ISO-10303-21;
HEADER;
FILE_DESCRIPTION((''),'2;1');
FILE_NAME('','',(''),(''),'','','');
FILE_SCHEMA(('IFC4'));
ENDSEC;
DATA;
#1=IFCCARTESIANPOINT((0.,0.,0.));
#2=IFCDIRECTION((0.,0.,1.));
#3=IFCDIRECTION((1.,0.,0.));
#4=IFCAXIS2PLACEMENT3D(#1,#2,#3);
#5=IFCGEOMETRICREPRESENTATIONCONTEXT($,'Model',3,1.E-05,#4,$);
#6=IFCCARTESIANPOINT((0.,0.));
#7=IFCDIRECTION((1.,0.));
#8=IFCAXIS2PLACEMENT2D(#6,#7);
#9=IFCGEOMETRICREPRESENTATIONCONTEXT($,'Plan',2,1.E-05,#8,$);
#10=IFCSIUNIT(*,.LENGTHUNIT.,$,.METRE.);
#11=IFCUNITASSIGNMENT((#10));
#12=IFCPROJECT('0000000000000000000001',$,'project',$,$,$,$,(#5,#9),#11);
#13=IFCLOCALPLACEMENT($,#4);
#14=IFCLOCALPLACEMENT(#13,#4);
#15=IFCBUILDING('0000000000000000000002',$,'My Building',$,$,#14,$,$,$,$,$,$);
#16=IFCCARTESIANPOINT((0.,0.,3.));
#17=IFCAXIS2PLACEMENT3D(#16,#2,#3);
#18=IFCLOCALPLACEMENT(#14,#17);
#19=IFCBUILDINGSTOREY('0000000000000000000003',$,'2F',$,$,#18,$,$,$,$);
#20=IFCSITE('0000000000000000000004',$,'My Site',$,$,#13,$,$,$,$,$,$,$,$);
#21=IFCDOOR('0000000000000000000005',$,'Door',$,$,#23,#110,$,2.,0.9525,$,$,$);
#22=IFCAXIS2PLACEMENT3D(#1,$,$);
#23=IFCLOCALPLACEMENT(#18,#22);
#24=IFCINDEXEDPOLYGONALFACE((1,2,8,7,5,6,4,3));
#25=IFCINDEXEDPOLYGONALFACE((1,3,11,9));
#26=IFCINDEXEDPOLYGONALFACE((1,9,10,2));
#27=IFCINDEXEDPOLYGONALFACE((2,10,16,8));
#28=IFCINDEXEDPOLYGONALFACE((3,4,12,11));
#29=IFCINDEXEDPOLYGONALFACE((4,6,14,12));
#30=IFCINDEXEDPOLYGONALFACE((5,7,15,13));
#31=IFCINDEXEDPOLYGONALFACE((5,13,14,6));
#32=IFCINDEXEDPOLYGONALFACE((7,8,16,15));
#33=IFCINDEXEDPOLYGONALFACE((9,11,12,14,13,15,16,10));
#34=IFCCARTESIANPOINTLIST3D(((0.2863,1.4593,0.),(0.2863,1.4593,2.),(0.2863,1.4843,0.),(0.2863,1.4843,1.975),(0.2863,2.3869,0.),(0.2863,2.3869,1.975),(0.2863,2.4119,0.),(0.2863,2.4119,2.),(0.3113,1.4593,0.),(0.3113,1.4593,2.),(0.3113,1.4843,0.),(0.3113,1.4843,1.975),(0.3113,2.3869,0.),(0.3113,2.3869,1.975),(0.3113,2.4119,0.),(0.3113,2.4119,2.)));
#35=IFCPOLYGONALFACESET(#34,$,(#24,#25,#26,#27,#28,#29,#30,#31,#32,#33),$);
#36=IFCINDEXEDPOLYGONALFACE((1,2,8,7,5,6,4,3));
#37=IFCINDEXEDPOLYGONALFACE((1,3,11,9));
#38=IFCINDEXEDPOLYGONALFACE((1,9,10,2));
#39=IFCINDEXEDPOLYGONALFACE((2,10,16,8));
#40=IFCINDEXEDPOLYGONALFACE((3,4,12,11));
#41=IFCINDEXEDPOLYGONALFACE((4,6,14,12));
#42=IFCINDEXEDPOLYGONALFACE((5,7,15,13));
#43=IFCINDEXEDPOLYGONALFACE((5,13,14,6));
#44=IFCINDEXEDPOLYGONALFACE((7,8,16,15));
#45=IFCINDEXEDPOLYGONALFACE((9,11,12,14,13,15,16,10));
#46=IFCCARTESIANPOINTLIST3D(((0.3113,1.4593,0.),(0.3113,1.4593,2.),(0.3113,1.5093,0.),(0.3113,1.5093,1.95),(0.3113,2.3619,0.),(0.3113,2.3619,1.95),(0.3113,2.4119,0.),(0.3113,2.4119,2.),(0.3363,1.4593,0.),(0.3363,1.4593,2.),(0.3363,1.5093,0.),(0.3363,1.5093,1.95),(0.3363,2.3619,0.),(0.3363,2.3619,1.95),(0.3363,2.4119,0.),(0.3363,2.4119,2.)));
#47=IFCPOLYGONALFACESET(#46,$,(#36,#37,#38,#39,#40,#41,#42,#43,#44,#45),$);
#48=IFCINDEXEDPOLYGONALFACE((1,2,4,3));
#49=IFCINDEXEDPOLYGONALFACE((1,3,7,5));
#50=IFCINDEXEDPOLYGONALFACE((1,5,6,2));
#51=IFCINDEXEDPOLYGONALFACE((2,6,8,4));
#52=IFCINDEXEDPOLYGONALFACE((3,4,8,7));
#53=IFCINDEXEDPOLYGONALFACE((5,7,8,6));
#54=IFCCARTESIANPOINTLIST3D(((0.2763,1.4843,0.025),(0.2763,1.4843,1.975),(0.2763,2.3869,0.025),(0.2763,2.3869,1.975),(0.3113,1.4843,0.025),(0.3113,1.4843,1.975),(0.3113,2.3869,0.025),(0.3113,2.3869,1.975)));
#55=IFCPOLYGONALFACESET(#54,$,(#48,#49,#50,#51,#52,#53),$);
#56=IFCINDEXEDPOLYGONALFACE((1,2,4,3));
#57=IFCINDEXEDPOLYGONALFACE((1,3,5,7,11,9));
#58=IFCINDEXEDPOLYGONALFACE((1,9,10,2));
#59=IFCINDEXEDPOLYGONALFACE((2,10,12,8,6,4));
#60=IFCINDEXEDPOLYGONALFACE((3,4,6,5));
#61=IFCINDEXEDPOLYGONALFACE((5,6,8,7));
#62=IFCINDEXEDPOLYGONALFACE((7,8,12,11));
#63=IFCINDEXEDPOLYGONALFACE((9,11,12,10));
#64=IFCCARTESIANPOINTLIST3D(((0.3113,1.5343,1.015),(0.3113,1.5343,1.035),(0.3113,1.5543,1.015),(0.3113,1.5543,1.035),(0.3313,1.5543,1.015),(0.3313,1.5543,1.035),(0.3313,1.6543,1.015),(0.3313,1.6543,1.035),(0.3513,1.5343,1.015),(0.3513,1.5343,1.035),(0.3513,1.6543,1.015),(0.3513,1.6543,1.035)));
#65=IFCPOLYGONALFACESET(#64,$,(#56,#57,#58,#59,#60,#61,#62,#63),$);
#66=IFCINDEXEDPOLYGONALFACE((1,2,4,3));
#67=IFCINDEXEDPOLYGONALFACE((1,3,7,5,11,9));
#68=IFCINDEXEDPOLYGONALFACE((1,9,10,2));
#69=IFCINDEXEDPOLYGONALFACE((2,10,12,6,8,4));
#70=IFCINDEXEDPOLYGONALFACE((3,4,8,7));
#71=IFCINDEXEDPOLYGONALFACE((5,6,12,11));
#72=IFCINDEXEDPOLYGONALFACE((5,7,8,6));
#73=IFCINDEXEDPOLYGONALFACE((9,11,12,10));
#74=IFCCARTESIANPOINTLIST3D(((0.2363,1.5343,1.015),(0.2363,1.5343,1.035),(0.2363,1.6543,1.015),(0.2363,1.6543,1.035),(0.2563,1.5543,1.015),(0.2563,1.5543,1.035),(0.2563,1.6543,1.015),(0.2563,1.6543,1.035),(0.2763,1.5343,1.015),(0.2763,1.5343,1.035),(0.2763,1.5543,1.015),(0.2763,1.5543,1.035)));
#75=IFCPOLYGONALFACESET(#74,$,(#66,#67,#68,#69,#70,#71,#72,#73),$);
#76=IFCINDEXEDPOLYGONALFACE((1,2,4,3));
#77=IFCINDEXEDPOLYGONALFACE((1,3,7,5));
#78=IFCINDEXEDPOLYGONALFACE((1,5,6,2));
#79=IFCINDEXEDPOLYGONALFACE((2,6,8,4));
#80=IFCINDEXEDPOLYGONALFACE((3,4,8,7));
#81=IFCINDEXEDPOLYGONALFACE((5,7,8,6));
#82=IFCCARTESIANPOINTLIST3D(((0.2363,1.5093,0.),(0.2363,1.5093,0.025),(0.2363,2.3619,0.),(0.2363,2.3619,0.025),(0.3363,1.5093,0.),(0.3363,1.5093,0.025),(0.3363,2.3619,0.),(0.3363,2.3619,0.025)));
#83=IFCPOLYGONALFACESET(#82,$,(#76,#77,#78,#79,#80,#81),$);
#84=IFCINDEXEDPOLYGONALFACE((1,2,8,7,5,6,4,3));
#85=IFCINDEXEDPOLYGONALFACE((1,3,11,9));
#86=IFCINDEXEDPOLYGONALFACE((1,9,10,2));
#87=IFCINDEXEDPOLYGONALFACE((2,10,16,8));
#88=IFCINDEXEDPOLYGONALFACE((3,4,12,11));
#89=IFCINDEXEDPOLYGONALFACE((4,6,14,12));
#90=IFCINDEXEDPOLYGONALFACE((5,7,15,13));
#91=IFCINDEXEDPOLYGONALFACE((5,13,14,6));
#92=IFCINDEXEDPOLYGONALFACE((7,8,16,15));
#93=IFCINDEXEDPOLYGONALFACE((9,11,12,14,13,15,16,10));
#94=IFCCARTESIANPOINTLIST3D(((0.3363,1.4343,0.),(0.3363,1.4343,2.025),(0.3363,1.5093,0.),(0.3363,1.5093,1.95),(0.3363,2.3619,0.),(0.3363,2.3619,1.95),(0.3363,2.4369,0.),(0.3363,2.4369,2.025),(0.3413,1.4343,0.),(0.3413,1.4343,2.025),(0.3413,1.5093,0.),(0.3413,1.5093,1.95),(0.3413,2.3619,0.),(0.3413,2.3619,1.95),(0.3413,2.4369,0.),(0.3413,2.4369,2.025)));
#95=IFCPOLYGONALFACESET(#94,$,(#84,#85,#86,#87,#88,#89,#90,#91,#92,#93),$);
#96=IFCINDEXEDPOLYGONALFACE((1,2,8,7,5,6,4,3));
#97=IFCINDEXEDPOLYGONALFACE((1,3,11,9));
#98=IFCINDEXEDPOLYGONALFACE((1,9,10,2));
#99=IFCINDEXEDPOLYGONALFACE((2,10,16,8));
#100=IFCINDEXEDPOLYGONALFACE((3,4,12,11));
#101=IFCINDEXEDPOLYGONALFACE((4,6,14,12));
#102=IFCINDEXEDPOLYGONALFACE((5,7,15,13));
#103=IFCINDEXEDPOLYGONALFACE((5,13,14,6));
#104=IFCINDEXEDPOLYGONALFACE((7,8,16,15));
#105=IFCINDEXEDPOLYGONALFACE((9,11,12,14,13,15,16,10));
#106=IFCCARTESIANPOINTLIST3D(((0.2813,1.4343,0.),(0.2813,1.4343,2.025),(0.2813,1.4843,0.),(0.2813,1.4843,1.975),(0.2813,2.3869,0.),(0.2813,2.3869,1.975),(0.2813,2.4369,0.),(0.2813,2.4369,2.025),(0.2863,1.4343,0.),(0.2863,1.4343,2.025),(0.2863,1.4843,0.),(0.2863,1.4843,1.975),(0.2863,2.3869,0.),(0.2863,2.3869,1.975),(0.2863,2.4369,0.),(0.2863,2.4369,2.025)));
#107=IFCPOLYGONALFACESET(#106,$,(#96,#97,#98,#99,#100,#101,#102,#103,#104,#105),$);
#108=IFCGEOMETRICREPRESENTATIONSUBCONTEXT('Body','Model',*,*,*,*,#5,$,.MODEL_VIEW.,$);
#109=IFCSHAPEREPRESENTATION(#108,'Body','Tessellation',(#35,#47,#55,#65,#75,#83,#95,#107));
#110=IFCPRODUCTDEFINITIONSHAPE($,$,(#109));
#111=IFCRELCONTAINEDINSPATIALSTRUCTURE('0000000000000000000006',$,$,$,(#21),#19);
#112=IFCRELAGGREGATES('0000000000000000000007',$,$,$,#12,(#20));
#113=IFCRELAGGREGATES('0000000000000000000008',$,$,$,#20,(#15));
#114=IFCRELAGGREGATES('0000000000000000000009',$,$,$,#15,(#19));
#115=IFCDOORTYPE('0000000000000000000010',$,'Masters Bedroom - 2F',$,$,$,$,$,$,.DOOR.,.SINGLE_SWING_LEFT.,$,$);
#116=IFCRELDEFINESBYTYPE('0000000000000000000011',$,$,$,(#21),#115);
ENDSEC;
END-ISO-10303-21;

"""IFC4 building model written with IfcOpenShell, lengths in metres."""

from ifc_helpers import new_model, entity, si_unit, frame, origin_with_axes, origin_2d_with_axis, place, context, subcontext, project, spatial, line, indexed_curve, outline, extrude, shape, source, transform, mapped, type_object, type_shapes, element, save


model = new_model("IFC4")

# Units and contexts
model_context = context("Model", 3, precision=1e-05, world=origin_with_axes())
plan_context = context("Plan", 2, precision=1e-05, world=origin_2d_with_axis())
body_context_1 = subcontext(model_context, "Body", "Model", "MODEL_VIEW")
body_context_2 = subcontext(plan_context, "Body", "Plan", "PLAN_VIEW")
ifc_project = project(units=[si_unit("LENGTHUNIT", "METRE")], contexts=[model_context, plan_context])

# Site, building, storey
site_placement = place(None, origin_with_axes())
site = spatial("IfcSite", under=ifc_project, at=site_placement, Name="My Site")
building_placement = place(site_placement, origin_with_axes())
building = spatial("IfcBuilding", under=site, at=building_placement, Name="My Building")
storey_placement = place(building_placement, frame((0.0, 0.0, 3.0), z_axis=(0.0, 0.0, 1.0), x_axis=(1.0, 0.0, 0.0)))
storey = spatial("IfcBuildingStorey", under=building, at=storey_placement, Name="2F")

# Door
door_type_1 = type_object("IfcDoorType", Name="Masters Bedroom - 2F", OperationType="SINGLE_SWING_LEFT", PredefinedType="DOOR")
shared_shape_1 = source(origin_with_axes(), body_context_1, "Body", "SweptSolid", [
    extrude(outline(indexed_curve([(0.0, 0.0), (0.0, 2.0), (0.9525, 2.0), (0.9525, 0.0), (0.9275, 0.0), (0.9275, 1.975), (0.025, 1.975), (0.025, 0.0)], segments=[line(1, 2, 3, 4, 5, 6, 7, 8, 1)])), frame((0.0, 0.025, 0.0), z_axis=(0.0, -1.0, 0.0), x_axis=(1.0, 0.0, 0.0)), (0.0, 0.0, -1.0), 0.025),
    extrude(outline(indexed_curve([(0.0, 0.0), (0.0, 2.0), (0.9525, 2.0), (0.9525, 0.0), (0.9025, 0.0), (0.9025, 1.95), (0.05, 1.95), (0.05, 0.0)], segments=[line(1, 2, 3, 4, 5, 6, 7, 8, 1)])), frame((0.0, 0.0, 0.0), z_axis=(0.0, -1.0, 0.0), x_axis=(1.0, 0.0, 0.0)), (0.0, 0.0, -1.0), 0.025),
    extrude(outline(indexed_curve([(0.0, 0.0), (0.9025, 0.0), (0.9025, 0.035), (0.0, 0.035)], segments=[line(1, 2, 3, 4, 1)])), frame((0.025, 0.025, 0.025), z_axis=(0.0, 0.0, 1.0), x_axis=(1.0, 0.0, 0.0)), (0.0, 0.0, 1.0), 1.95),
    extrude(outline(indexed_curve([(0.0, 0.0), (0.0, -0.04), (0.12, -0.04), (0.12, -0.02), (0.02, -0.02), (0.02, 0.0)], segments=[line(1, 2, 3, 4, 5, 6, 1)])), frame((0.075, 0.025, 1.015), z_axis=(0.0, 0.0, 1.0), x_axis=(1.0, 0.0, 0.0)), (0.0, 0.0, 1.0), 0.02),
    extrude(outline(indexed_curve([(0.0, 0.0), (0.0, 0.04), (0.12, 0.04), (0.12, 0.02), (0.02, 0.02), (0.02, 0.0)], segments=[line(1, 2, 3, 4, 5, 6, 1)])), frame((0.075, 0.06, 1.015), z_axis=(0.0, 0.0, 1.0), x_axis=(1.0, 0.0, 0.0)), (0.0, 0.0, 1.0), 0.02),
    extrude(outline(indexed_curve([(0.0, 0.0), (0.8525, 0.0), (0.8525, 0.1), (0.0, 0.1)], segments=[line(1, 2, 3, 4, 1)])), frame((0.05, 0.0, 0.0), z_axis=(0.0, 0.0, 1.0), x_axis=(1.0, 0.0, 0.0)), (0.0, 0.0, 1.0), 0.025),
    extrude(outline(indexed_curve([(0.0, 0.0), (0.0, 2.025), (1.0025, 2.025), (1.0025, 0.0), (0.9275, 0.0), (0.9275, 1.95), (0.075, 1.95), (0.075, 0.0)], segments=[line(1, 2, 3, 4, 5, 6, 7, 8, 1)])), frame((-0.025, -0.005, 0.0), z_axis=(0.0, -1.0, 0.0), x_axis=(1.0, 0.0, 0.0)), (0.0, 0.0, -1.0), 0.005),
    extrude(outline(indexed_curve([(0.0, 0.0), (0.0, 2.025), (1.0025, 2.025), (1.0025, 0.0), (0.9525, 0.0), (0.9525, 1.975), (0.05, 1.975), (0.05, 0.0)], segments=[line(1, 2, 3, 4, 5, 6, 7, 8, 1)])), frame((-0.025, 0.05, 0.0), z_axis=(0.0, -1.0, 0.0), x_axis=(1.0, 0.0, 0.0)), (0.0, 0.0, -1.0), 0.005),
])
shared_shape_2 = source(origin_with_axes(), body_context_2, "Body", "Curve2D", [
    entity("IfcIndexedPolyCurve", entity("IfcCartesianPointList2D", [[0.0, 0.0], [0.0, 0.05], [0.025, 0.05], [0.025, 0.025], [0.05, 0.025], [0.05, 0.0]]), [entity("IfcLineIndex", [1, 2, 3, 4, 5, 6, 1])]),
    entity("IfcIndexedPolyCurve", entity("IfcCartesianPointList2D", [[0.9525, 0.0], [0.9525, 0.05], [0.9275, 0.05], [0.9275, 0.025], [0.9025, 0.025], [0.9025, 0.0]]), [entity("IfcLineIndex", [1, 2, 3, 4, 5, 6, 1])]),
    entity("IfcTrimmedCurve", entity("IfcEllipse", entity("IfcAxis2Placement2D", entity("IfcCartesianPoint", [0.8925, 0.05]), entity("IfcDirection", [1.0, 0.0])), 0.8675, 0.9025), [entity("IfcCartesianPoint", [0.8925, 0.9525])], [entity("IfcCartesianPoint", [0.025, 0.05])], True, "CARTESIAN"),
    entity("IfcIndexedPolyCurve", entity("IfcCartesianPointList2D", [[0.9275, 0.05], [0.8925, 0.05], [0.8925, 0.9525], [0.9275, 0.9525]]), [entity("IfcLineIndex", [1, 2, 3, 4, 1])]),
])
type_shapes(door_type_1, [shared_shape_1, shared_shape_2])
placement_1 = place(storey_placement, frame((0.2363, 2.337, 0.0), z_axis=(0.0, 0.0, 1.0), x_axis=(0.0, -1.0, 0.0)))
placement_2 = place(placement_1, frame((0.8777, 0.1, 0.0), z_axis=(0.0, 0.0, 1.0), x_axis=(-1.0, 0.0, 0.0)))
door_1_placement = place(placement_2, frame((0.0, 0.0, 0.0), z_axis=(0.0, 0.0, 1.0), x_axis=(1.0, 0.0, 0.0)))
element("IfcDoor", 1, at=door_1_placement, inside=storey, type_object=door_type_1, Name="Door", OverallHeight=2.0, OverallWidth=0.9525, shapes=[
    shape(body_context_1, "Body", "MappedRepresentation", [mapped(shared_shape_1, transform((0.0, 0.0, 0.0), x_axis=(1.0, 0.0, 0.0), y_axis=(0.0, 1.0, 0.0), z_axis=(0.0, 0.0, 1.0), scale=1.0))]),
    shape(body_context_2, "Body", "MappedRepresentation", [mapped(shared_shape_2, transform((0.0, 0.0, 0.0), x_axis=(1.0, 0.0, 0.0), y_axis=(0.0, 1.0, 0.0), z_axis=(0.0, 0.0, 1.0), scale=1.0))]),
])

save(model, "model.ifc")
